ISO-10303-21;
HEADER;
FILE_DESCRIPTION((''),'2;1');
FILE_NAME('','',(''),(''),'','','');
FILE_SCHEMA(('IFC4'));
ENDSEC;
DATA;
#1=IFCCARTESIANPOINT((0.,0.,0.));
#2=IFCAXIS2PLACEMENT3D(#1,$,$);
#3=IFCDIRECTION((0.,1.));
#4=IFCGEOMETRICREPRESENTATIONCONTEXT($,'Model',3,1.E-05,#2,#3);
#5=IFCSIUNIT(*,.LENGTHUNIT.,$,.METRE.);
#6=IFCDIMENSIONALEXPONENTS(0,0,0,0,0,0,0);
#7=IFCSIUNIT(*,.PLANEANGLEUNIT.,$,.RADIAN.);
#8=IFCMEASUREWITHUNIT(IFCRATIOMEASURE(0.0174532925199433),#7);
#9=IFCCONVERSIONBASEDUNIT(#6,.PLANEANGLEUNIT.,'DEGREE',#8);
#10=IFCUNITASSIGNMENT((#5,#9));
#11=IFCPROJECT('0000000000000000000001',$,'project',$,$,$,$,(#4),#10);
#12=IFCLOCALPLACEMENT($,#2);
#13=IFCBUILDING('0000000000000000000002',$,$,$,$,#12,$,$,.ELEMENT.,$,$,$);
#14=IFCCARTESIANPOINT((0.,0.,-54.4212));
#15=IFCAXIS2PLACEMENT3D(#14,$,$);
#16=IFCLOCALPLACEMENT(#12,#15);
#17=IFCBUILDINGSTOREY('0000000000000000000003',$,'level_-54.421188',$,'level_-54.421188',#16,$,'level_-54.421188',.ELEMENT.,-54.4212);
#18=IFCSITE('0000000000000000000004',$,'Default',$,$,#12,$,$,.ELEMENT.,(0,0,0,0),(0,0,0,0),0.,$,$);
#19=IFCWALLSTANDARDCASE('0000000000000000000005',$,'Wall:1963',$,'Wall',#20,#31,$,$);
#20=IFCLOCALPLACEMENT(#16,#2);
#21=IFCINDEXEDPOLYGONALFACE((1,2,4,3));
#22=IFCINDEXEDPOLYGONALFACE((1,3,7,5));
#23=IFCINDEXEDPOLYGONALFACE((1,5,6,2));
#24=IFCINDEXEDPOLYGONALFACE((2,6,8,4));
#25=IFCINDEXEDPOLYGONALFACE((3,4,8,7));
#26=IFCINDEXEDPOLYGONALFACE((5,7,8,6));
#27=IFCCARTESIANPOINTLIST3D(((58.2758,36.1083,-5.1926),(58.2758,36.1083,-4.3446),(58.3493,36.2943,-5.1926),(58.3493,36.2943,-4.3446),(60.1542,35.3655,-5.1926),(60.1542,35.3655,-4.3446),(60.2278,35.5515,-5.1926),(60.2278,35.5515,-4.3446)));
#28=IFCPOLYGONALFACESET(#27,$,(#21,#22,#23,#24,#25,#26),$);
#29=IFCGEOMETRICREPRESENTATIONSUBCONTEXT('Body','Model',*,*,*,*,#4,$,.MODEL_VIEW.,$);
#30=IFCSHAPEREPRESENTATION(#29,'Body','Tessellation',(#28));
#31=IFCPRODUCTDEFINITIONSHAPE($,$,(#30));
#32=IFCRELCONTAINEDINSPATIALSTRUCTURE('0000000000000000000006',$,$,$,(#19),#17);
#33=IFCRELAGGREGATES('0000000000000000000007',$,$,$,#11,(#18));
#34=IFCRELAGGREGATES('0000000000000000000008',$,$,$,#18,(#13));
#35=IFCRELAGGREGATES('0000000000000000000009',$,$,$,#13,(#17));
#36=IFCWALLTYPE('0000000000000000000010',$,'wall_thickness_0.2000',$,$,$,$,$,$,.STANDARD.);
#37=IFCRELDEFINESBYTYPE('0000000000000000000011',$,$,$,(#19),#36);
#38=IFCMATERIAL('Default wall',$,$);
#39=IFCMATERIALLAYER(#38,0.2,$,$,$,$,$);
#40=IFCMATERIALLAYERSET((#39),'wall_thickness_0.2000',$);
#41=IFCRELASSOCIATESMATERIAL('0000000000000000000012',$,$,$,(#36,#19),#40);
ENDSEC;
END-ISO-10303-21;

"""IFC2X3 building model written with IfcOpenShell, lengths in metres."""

from ifc_helpers import new_model, entity, si_unit, converted_unit, direction, frame, origin, place, context, subcontext, project, spatial, polyline, outline, extrude, material, layer, layer_set, layer_usage, type_object, element, save


model = new_model("IFC2X3")

# Units and contexts
model_context = context("Model", 3, precision=1e-05, world=origin(), true_north=direction((0.0, 1.0)))
body_context = subcontext(model_context, "Body", "Model", "MODEL_VIEW")
ifc_project = project(units=[si_unit("LENGTHUNIT", "METRE"), converted_unit("PLANEANGLEUNIT", "DEGREE", entity("IfcRatioMeasure", 0.0174532925199433), si_unit("PLANEANGLEUNIT", "RADIAN"), dimensions=[0, 0, 0, 0, 0, 0, 0])], contexts=[model_context])

# Site, building, storey
placement_1 = place(None, origin())
site = spatial("IfcSite", under=ifc_project, at=placement_1, Name="Default", CompositionType="ELEMENT", RefLatitude=(0, 0, 0, 0), RefLongitude=(0, 0, 0, 0), RefElevation=0.0)
building = spatial("IfcBuilding", under=site, at=placement_1, CompositionType="ELEMENT")
storey_placement = place(placement_1, frame((0.0, 0.0, -54.4212)))
storey = spatial("IfcBuildingStorey", under=building, at=storey_placement, Name="level_-54.421188", ObjectType="level_-54.421188", LongName="level_-54.421188", CompositionType="ELEMENT", Elevation=-54.4212)

# Shared definitions
ifc_material_1 = material(Name="Default wall")
ifc_layer = layer(ifc_material_1, 0.2)
ifc_layer_set = layer_set([ifc_layer], Name="wall_thickness_0.2000")
ifc_layer_usage = layer_usage(ifc_layer_set, "AXIS2", "POSITIVE", -0.1)
wall_type = type_object("IfcWallType", Name="wall_thickness_0.2000", PredefinedType="STANDARD", material=ifc_layer_set)

# Wall
placement_2 = place(placement_1, frame((0.0, 0.0, -59.6138)))
wall_1_placement = place(placement_2, frame((58.3125, 36.2013, 0.0), z_axis=(0.0, 0.0, 1.0), x_axis=(0.929928, -0.367743, 0.0)))
element("IfcWallStandardCase", 1, at=wall_1_placement, inside=storey, type_object=wall_type, material=ifc_layer_usage, Name="Wall:1963", ObjectType="Wall", context=body_context, shape_type="SweptSolid", body=[
    extrude(outline(polyline([(2.02, -0.1), (2.02, 0.1), (0.0, 0.1), (0.0, -0.1), (2.02, -0.1)])), origin(), (0.0, 0.0, 1.0), 0.848),
])

save(model, "model.ifc")
